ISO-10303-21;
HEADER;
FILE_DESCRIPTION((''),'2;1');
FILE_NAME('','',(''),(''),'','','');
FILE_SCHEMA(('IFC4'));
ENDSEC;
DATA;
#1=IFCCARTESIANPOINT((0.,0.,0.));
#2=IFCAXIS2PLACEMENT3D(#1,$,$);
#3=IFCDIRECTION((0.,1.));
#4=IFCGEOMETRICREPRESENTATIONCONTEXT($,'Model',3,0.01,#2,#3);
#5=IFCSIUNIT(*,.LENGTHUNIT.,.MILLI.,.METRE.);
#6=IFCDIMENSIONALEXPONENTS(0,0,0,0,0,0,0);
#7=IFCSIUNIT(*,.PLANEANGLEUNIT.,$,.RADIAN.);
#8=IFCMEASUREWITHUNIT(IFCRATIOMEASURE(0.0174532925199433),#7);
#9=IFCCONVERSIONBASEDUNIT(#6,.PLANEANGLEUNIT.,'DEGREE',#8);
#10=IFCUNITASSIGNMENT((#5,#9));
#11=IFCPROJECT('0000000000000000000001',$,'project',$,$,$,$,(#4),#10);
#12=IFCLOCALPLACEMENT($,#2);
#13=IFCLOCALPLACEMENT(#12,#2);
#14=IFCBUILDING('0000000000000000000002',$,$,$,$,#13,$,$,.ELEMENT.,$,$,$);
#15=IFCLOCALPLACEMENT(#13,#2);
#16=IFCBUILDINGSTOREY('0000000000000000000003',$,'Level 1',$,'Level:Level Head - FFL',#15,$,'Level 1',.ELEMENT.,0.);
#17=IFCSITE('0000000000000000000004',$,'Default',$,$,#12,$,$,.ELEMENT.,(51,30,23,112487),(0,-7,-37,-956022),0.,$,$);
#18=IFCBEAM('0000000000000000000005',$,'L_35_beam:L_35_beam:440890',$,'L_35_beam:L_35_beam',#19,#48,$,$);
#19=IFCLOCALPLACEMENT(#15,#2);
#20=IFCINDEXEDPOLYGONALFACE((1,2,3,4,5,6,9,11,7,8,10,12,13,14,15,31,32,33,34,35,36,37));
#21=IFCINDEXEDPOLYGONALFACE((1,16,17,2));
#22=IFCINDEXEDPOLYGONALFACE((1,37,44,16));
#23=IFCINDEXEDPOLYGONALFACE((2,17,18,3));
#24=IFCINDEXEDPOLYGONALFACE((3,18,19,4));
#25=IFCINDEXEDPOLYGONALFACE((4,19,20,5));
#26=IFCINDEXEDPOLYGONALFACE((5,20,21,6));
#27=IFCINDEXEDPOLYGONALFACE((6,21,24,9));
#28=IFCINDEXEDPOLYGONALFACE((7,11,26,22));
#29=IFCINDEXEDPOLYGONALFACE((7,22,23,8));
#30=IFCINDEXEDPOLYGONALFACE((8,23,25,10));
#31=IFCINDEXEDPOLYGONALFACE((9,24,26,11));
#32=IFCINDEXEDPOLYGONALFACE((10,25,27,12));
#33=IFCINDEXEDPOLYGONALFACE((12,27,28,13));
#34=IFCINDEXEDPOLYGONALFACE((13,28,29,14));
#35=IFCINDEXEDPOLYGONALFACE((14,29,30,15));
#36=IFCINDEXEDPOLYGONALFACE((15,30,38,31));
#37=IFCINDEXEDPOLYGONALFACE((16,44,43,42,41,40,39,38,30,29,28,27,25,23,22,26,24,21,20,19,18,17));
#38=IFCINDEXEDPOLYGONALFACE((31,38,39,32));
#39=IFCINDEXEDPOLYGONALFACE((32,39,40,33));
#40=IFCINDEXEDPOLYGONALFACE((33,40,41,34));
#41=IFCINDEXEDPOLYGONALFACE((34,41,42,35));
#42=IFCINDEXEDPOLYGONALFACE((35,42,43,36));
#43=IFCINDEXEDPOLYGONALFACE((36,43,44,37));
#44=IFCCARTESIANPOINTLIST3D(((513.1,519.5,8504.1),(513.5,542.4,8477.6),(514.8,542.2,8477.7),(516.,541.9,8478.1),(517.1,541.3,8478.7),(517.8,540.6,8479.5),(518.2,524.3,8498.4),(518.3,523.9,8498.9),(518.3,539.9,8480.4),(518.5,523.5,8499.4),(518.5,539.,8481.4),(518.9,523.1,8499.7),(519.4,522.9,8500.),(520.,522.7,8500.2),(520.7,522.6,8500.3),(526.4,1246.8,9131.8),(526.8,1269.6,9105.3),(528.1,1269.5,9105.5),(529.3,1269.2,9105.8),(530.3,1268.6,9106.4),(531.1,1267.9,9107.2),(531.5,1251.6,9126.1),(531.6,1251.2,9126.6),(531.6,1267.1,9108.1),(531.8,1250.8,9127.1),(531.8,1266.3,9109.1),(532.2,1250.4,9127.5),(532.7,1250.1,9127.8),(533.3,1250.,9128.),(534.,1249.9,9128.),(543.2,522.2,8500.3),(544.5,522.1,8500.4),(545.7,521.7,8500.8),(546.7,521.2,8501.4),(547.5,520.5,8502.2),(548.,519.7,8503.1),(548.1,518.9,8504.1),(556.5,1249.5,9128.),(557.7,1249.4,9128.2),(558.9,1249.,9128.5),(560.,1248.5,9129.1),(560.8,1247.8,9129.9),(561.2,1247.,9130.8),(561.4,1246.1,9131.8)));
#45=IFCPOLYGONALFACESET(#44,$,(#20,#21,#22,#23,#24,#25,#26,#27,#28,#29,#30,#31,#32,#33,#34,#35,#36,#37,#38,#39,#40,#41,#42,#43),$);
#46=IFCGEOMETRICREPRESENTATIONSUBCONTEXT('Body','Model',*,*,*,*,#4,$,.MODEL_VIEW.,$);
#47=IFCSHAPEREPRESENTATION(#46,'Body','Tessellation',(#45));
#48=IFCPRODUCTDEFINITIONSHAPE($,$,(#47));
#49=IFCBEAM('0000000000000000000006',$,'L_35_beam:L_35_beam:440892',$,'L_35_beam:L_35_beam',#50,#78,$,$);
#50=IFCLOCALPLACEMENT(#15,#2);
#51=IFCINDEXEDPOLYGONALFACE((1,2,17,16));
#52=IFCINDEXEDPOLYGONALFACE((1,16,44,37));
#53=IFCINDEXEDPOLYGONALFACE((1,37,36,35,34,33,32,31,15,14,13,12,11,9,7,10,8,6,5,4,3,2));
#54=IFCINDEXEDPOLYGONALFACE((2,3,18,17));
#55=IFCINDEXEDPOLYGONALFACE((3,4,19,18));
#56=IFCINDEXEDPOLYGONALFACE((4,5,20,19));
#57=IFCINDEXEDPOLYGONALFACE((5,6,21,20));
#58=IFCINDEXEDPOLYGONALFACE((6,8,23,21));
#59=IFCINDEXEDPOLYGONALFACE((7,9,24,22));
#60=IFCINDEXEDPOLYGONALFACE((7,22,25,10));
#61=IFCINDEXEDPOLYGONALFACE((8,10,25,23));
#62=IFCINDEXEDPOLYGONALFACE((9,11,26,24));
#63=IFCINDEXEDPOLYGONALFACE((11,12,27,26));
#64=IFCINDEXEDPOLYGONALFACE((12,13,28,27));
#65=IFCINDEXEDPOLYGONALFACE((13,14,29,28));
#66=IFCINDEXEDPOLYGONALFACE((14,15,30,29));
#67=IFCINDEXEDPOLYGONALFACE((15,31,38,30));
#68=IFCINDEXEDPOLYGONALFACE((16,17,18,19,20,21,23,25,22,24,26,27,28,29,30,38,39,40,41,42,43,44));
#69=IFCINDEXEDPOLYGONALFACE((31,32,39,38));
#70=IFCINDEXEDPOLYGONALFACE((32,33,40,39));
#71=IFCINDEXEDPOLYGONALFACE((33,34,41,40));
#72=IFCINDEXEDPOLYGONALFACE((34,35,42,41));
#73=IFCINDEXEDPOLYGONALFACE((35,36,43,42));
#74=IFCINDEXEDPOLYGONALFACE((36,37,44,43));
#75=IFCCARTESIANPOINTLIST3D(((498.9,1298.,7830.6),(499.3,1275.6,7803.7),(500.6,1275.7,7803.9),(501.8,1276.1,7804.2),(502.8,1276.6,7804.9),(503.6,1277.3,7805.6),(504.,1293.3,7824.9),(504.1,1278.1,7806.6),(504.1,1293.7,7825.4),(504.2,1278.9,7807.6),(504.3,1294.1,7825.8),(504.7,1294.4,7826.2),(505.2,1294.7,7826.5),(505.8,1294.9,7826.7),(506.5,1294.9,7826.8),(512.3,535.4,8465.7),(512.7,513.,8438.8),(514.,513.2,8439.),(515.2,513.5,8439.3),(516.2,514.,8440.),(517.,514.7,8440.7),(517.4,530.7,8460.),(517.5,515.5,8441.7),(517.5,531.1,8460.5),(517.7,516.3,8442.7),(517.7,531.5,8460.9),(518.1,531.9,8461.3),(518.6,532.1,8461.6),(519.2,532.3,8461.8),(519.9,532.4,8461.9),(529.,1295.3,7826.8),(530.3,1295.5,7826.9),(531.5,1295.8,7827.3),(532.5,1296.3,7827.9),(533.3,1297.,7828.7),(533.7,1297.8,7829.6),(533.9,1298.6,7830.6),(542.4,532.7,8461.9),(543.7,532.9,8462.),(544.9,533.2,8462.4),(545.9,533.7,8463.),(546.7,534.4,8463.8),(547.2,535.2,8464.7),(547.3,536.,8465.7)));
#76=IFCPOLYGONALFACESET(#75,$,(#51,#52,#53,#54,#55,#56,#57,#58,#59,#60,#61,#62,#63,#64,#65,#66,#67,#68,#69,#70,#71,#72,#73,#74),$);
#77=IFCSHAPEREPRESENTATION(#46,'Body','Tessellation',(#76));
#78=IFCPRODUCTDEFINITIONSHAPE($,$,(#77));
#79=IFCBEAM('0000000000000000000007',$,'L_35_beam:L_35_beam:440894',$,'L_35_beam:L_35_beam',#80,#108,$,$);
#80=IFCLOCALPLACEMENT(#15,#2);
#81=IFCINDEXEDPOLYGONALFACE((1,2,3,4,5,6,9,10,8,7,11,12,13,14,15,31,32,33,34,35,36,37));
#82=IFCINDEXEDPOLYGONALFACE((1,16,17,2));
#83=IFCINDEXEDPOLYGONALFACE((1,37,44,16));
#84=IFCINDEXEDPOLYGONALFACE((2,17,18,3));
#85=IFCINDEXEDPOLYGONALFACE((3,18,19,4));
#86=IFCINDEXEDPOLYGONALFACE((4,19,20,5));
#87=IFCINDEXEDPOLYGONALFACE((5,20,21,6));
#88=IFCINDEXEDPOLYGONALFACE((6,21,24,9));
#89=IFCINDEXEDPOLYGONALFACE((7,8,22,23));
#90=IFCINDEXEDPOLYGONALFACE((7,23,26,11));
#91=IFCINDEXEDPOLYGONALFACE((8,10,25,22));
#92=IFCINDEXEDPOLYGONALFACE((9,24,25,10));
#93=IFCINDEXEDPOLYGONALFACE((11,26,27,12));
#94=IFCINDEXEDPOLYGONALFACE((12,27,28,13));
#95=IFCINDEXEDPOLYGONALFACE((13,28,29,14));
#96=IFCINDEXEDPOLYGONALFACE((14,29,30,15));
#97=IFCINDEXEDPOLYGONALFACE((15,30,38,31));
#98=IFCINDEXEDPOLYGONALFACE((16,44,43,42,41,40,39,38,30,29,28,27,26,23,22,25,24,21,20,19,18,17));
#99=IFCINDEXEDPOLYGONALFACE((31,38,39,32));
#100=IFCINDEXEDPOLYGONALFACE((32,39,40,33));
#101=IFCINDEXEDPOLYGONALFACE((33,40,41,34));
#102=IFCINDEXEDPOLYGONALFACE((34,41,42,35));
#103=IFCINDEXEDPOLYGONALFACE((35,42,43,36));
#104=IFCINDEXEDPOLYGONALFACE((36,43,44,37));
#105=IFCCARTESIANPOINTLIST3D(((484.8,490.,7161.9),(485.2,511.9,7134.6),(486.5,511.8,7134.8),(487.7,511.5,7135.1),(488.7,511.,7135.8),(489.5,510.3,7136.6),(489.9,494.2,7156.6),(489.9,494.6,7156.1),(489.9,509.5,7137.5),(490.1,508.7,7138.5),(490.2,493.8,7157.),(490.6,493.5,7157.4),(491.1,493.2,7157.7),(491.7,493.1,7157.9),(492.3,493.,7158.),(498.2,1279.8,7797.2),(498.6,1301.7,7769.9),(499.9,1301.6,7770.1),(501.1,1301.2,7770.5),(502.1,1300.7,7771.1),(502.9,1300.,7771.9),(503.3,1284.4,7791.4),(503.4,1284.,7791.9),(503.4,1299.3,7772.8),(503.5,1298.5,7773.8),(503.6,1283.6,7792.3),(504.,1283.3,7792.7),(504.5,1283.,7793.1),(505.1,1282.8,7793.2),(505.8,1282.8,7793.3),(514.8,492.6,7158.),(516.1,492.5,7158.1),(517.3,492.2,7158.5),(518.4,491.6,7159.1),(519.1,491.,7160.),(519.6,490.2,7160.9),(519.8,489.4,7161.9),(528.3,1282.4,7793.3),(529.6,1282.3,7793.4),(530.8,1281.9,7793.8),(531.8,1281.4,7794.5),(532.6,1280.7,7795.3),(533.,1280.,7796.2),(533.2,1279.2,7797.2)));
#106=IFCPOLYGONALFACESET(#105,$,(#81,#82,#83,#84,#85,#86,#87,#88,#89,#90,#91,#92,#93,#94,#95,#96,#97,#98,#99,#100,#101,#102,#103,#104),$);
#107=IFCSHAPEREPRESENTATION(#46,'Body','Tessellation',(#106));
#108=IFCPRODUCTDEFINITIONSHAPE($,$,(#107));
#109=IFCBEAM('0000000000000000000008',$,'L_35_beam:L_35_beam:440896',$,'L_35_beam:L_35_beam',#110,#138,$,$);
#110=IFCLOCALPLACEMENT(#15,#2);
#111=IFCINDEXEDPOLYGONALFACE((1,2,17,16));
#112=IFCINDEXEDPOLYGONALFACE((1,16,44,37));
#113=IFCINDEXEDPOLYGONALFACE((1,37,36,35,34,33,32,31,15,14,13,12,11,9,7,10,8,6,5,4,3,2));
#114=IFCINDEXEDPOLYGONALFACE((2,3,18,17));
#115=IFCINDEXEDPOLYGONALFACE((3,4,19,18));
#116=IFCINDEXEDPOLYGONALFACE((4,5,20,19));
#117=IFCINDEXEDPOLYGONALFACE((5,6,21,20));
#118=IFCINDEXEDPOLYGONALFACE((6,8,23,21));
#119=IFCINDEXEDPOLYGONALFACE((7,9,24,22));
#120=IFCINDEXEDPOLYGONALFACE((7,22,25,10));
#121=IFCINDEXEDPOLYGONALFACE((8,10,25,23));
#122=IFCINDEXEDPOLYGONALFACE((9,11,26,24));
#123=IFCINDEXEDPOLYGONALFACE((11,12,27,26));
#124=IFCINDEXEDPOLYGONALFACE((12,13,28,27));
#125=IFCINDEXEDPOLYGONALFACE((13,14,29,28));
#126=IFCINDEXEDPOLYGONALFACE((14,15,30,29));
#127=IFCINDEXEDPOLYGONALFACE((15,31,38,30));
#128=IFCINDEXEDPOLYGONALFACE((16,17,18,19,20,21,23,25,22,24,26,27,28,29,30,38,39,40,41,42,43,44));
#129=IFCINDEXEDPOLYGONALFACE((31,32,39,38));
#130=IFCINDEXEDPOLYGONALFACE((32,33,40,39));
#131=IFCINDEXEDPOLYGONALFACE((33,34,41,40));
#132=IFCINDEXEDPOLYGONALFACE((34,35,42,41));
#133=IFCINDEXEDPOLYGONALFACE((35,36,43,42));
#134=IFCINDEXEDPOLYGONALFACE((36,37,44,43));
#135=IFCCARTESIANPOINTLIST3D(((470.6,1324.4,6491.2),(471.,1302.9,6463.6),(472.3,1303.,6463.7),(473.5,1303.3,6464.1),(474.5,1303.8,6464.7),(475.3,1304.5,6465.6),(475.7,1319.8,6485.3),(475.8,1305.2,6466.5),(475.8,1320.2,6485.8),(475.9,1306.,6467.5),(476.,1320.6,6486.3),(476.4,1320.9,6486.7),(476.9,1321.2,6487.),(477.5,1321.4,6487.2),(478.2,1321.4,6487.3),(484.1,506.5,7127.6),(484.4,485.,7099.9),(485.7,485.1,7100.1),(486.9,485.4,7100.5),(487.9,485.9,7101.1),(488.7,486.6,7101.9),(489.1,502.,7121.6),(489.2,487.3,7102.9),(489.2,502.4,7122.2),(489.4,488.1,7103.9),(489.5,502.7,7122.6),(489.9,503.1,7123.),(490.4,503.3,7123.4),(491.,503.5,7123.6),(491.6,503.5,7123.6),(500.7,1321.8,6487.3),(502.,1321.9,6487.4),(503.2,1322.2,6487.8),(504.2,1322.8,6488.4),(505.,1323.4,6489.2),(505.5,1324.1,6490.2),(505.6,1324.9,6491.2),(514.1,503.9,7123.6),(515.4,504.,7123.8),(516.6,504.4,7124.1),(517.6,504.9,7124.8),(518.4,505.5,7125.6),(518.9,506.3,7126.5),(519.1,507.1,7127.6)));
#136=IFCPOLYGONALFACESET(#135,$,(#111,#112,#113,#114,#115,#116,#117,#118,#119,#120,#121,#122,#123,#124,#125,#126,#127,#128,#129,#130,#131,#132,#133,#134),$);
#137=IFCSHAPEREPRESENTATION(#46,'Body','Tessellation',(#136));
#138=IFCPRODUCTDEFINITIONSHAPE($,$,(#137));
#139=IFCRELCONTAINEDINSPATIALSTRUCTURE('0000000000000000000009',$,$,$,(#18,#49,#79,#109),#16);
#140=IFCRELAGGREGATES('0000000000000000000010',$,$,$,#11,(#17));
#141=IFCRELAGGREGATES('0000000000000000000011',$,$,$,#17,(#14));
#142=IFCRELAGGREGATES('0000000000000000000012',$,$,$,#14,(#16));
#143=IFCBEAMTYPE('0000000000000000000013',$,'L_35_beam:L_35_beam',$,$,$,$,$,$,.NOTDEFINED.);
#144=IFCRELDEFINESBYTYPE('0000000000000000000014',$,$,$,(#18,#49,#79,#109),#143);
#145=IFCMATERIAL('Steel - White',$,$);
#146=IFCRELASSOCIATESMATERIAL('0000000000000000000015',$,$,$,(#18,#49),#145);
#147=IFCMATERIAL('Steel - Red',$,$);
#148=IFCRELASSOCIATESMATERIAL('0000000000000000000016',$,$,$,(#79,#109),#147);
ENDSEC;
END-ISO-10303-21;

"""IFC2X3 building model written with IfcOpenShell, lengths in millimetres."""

from ifc_helpers import new_model, entity, si_unit, converted_unit, direction, frame, frame_2d, origin, place, context, subcontext, project, spatial, polyline, circle_curve, parameter, trimmed, segment, composite_curve, outline, extrude, material, type_object, element, save


model = new_model("IFC2X3")

# Units and contexts
model_context = context("Model", 3, precision=0.01, world=origin(), true_north=direction((0.0, 1.0)))
body_context = subcontext(model_context, "Body", "Model", "MODEL_VIEW")
ifc_project = project(units=[si_unit("LENGTHUNIT", "METRE", prefix="MILLI"), converted_unit("PLANEANGLEUNIT", "DEGREE", entity("IfcRatioMeasure", 0.0174532925199433), si_unit("PLANEANGLEUNIT", "RADIAN"), dimensions=[0, 0, 0, 0, 0, 0, 0])], contexts=[model_context])

# Site, building, storey
site_placement = place(None, origin())
site = spatial("IfcSite", under=ifc_project, at=site_placement, Name="Default", CompositionType="ELEMENT", RefLatitude=(51, 30, 23, 112487), RefLongitude=(0, -7, -37, -956022), RefElevation=0.0)
building_placement = place(site_placement, origin())
building = spatial("IfcBuilding", under=site, at=building_placement, CompositionType="ELEMENT")
storey_placement = place(building_placement, origin())
storey = spatial("IfcBuildingStorey", under=building, at=storey_placement, Name="Level 1", ObjectType="Level:Level Head - FFL", LongName="Level 1", CompositionType="ELEMENT", Elevation=0.0)

# Beams
ifc_material_1 = material(Name="Steel - Red")
ifc_material_2 = material(Name="Steel - White")
beam_type_1 = type_object("IfcBeamType", Name="L_35_beam:L_35_beam", PredefinedType="NOTDEFINED")
beam_1_placement = place(storey_placement, frame((504.9, 504.9, 8468.2), z_axis=(-0.011914, -0.653232, 0.757064), x_axis=(0.013805, 0.756938, 0.65334)))
element("IfcBeam", 1, at=beam_1_placement, inside=storey, type_object=beam_type_1, material=ifc_material_2, Name="L_35_beam:L_35_beam:440890", ObjectType="L_35_beam:L_35_beam", context=body_context, shape_type="SweptSolid", body=[
    extrude(outline(composite_curve([segment(polyline([(-23.2, -11.8), (11.8, -11.8)]), True, "CONTINUOUS"), segment(polyline([(11.8, -11.8), (11.8, 23.2)]), True, "CONTINUOUS"), segment(trimmed(circle_curve(frame_2d((11.8, 18.2), x_axis=(0.0, 1.0)), 5.0), [parameter(0.0)], [parameter(90.0)], True, "PARAMETER"), True, "CONTINUOUS"), segment(polyline([(6.8, 18.2), (6.8, -4.3)]), True, "CONTINUOUS"), segment(trimmed(circle_curve(frame_2d((4.3, -4.3), x_axis=(1.0, 0.0)), 2.5), [parameter(270.0)], [parameter(0.0)], True, "PARAMETER"), False, "CONTINUOUS"), segment(polyline([(4.3, -6.8), (-18.2, -6.8)]), True, "CONTINUOUS"), segment(trimmed(circle_curve(frame_2d((-18.2, -11.8), x_axis=(0.0, 1.0)), 5.0), [parameter(0.0)], [parameter(90.0)], True, "PARAMETER"), True, "CONTINUOUS")], self_intersect=False)), frame((34.6, -19.8, 5.7), z_axis=(1.0, 0.0, 0.0), x_axis=(0.0, 0.0, 1.0)), (0.0, 0.0, 1.0), 960.8),
])
beam_2_placement = place(storey_placement, frame((504.9, 504.9, 8468.2), z_axis=(-0.011258, 0.63979, 0.768467), x_axis=(-0.01352, 0.768348, -0.639889)))
element("IfcBeam", 2, at=beam_2_placement, inside=storey, type_object=beam_type_1, material=ifc_material_2, Name="L_35_beam:L_35_beam:440892", ObjectType="L_35_beam:L_35_beam", context=body_context, shape_type="SweptSolid", body=[
    extrude(outline(composite_curve([segment(polyline([(-23.2, -11.8), (11.8, -11.8)]), True, "CONTINUOUS"), segment(polyline([(11.8, -11.8), (11.8, 23.2)]), True, "CONTINUOUS"), segment(trimmed(circle_curve(frame_2d((11.8, 18.2), x_axis=(0.0, 1.0)), 5.0), [parameter(0.0)], [parameter(90.0)], True, "PARAMETER"), True, "CONTINUOUS"), segment(polyline([(6.8, 18.2), (6.8, -4.3)]), True, "CONTINUOUS"), segment(trimmed(circle_curve(frame_2d((4.3, -4.3), x_axis=(1.0, 0.0)), 2.5), [parameter(270.0)], [parameter(0.0)], True, "PARAMETER"), False, "CONTINUOUS"), segment(polyline([(4.3, -6.8), (-18.2, -6.8)]), True, "CONTINUOUS"), segment(trimmed(circle_curve(frame_2d((-18.2, -11.8), x_axis=(0.0, 1.0)), 5.0), [parameter(0.0)], [parameter(90.0)], True, "PARAMETER"), True, "CONTINUOUS")], self_intersect=False)), frame((25.0, -19.8, 5.7), z_axis=(1.0, 0.0, 0.0), x_axis=(0.0, 0.0, 1.0)), (0.0, 0.0, 1.0), 992.5),
])
beam_3_placement = place(storey_placement, frame((476.6, 476.6, 7128.5), z_axis=(-0.010652, -0.626653, 0.779225), x_axis=(0.013243, 0.779113, 0.626744)))
element("IfcBeam", 3, at=beam_3_placement, inside=storey, type_object=beam_type_1, material=ifc_material_1, Name="L_35_beam:L_35_beam:440894", ObjectType="L_35_beam:L_35_beam", context=body_context, shape_type="SweptSolid", body=[
    extrude(outline(composite_curve([segment(polyline([(-23.2, -11.8), (11.8, -11.8)]), True, "CONTINUOUS"), segment(polyline([(11.8, -11.8), (11.8, 23.2)]), True, "CONTINUOUS"), segment(trimmed(circle_curve(frame_2d((11.8, 18.2), x_axis=(0.0, 1.0)), 5.0), [parameter(0.0)], [parameter(90.0)], True, "PARAMETER"), True, "CONTINUOUS"), segment(polyline([(6.8, 18.2), (6.8, -4.3)]), True, "CONTINUOUS"), segment(trimmed(circle_curve(frame_2d((4.3, -4.3), x_axis=(1.0, 0.0)), 2.5), [parameter(270.0)], [parameter(0.0)], True, "PARAMETER"), False, "CONTINUOUS"), segment(polyline([(4.3, -6.8), (-18.2, -6.8)]), True, "CONTINUOUS"), segment(trimmed(circle_curve(frame_2d((-18.2, -11.8), x_axis=(0.0, 1.0)), 5.0), [parameter(0.0)], [parameter(90.0)], True, "PARAMETER"), True, "CONTINUOUS")], self_intersect=False)), frame((31.5, -19.8, 5.7), z_axis=(1.0, 0.0, 0.0), x_axis=(0.0, 0.0, 1.0)), (0.0, 0.0, 1.0), 1013.7),
])
beam_4_placement = place(storey_placement, frame((476.6, 476.6, 7128.5), z_axis=(-0.010092, 0.613935, 0.789292), x_axis=(-0.012973, 0.789185, -0.614018)))
element("IfcBeam", 4, at=beam_4_placement, inside=storey, type_object=beam_type_1, material=ifc_material_1, Name="L_35_beam:L_35_beam:440896", ObjectType="L_35_beam:L_35_beam", context=body_context, shape_type="SweptSolid", body=[
    extrude(outline(composite_curve([segment(polyline([(-23.2, -11.8), (11.8, -11.8)]), True, "CONTINUOUS"), segment(polyline([(11.8, -11.8), (11.8, 23.2)]), True, "CONTINUOUS"), segment(trimmed(circle_curve(frame_2d((11.8, 18.2), x_axis=(0.0, 1.0)), 5.0), [parameter(0.0)], [parameter(90.0)], True, "PARAMETER"), True, "CONTINUOUS"), segment(polyline([(6.8, 18.2), (6.8, -4.3)]), True, "CONTINUOUS"), segment(trimmed(circle_curve(frame_2d((4.3, -4.3), x_axis=(1.0, 0.0)), 2.5), [parameter(270.0)], [parameter(0.0)], True, "PARAMETER"), False, "CONTINUOUS"), segment(polyline([(4.3, -6.8), (-18.2, -6.8)]), True, "CONTINUOUS"), segment(trimmed(circle_curve(frame_2d((-18.2, -11.8), x_axis=(0.0, 1.0)), 5.0), [parameter(0.0)], [parameter(90.0)], True, "PARAMETER"), True, "CONTINUOUS")], self_intersect=False)), frame((24.1, -19.8, 5.7), z_axis=(1.0, 0.0, 0.0), x_axis=(0.0, 0.0, 1.0)), (0.0, 0.0, 1.0), 1036.4),
])

save(model, "model.ifc")
